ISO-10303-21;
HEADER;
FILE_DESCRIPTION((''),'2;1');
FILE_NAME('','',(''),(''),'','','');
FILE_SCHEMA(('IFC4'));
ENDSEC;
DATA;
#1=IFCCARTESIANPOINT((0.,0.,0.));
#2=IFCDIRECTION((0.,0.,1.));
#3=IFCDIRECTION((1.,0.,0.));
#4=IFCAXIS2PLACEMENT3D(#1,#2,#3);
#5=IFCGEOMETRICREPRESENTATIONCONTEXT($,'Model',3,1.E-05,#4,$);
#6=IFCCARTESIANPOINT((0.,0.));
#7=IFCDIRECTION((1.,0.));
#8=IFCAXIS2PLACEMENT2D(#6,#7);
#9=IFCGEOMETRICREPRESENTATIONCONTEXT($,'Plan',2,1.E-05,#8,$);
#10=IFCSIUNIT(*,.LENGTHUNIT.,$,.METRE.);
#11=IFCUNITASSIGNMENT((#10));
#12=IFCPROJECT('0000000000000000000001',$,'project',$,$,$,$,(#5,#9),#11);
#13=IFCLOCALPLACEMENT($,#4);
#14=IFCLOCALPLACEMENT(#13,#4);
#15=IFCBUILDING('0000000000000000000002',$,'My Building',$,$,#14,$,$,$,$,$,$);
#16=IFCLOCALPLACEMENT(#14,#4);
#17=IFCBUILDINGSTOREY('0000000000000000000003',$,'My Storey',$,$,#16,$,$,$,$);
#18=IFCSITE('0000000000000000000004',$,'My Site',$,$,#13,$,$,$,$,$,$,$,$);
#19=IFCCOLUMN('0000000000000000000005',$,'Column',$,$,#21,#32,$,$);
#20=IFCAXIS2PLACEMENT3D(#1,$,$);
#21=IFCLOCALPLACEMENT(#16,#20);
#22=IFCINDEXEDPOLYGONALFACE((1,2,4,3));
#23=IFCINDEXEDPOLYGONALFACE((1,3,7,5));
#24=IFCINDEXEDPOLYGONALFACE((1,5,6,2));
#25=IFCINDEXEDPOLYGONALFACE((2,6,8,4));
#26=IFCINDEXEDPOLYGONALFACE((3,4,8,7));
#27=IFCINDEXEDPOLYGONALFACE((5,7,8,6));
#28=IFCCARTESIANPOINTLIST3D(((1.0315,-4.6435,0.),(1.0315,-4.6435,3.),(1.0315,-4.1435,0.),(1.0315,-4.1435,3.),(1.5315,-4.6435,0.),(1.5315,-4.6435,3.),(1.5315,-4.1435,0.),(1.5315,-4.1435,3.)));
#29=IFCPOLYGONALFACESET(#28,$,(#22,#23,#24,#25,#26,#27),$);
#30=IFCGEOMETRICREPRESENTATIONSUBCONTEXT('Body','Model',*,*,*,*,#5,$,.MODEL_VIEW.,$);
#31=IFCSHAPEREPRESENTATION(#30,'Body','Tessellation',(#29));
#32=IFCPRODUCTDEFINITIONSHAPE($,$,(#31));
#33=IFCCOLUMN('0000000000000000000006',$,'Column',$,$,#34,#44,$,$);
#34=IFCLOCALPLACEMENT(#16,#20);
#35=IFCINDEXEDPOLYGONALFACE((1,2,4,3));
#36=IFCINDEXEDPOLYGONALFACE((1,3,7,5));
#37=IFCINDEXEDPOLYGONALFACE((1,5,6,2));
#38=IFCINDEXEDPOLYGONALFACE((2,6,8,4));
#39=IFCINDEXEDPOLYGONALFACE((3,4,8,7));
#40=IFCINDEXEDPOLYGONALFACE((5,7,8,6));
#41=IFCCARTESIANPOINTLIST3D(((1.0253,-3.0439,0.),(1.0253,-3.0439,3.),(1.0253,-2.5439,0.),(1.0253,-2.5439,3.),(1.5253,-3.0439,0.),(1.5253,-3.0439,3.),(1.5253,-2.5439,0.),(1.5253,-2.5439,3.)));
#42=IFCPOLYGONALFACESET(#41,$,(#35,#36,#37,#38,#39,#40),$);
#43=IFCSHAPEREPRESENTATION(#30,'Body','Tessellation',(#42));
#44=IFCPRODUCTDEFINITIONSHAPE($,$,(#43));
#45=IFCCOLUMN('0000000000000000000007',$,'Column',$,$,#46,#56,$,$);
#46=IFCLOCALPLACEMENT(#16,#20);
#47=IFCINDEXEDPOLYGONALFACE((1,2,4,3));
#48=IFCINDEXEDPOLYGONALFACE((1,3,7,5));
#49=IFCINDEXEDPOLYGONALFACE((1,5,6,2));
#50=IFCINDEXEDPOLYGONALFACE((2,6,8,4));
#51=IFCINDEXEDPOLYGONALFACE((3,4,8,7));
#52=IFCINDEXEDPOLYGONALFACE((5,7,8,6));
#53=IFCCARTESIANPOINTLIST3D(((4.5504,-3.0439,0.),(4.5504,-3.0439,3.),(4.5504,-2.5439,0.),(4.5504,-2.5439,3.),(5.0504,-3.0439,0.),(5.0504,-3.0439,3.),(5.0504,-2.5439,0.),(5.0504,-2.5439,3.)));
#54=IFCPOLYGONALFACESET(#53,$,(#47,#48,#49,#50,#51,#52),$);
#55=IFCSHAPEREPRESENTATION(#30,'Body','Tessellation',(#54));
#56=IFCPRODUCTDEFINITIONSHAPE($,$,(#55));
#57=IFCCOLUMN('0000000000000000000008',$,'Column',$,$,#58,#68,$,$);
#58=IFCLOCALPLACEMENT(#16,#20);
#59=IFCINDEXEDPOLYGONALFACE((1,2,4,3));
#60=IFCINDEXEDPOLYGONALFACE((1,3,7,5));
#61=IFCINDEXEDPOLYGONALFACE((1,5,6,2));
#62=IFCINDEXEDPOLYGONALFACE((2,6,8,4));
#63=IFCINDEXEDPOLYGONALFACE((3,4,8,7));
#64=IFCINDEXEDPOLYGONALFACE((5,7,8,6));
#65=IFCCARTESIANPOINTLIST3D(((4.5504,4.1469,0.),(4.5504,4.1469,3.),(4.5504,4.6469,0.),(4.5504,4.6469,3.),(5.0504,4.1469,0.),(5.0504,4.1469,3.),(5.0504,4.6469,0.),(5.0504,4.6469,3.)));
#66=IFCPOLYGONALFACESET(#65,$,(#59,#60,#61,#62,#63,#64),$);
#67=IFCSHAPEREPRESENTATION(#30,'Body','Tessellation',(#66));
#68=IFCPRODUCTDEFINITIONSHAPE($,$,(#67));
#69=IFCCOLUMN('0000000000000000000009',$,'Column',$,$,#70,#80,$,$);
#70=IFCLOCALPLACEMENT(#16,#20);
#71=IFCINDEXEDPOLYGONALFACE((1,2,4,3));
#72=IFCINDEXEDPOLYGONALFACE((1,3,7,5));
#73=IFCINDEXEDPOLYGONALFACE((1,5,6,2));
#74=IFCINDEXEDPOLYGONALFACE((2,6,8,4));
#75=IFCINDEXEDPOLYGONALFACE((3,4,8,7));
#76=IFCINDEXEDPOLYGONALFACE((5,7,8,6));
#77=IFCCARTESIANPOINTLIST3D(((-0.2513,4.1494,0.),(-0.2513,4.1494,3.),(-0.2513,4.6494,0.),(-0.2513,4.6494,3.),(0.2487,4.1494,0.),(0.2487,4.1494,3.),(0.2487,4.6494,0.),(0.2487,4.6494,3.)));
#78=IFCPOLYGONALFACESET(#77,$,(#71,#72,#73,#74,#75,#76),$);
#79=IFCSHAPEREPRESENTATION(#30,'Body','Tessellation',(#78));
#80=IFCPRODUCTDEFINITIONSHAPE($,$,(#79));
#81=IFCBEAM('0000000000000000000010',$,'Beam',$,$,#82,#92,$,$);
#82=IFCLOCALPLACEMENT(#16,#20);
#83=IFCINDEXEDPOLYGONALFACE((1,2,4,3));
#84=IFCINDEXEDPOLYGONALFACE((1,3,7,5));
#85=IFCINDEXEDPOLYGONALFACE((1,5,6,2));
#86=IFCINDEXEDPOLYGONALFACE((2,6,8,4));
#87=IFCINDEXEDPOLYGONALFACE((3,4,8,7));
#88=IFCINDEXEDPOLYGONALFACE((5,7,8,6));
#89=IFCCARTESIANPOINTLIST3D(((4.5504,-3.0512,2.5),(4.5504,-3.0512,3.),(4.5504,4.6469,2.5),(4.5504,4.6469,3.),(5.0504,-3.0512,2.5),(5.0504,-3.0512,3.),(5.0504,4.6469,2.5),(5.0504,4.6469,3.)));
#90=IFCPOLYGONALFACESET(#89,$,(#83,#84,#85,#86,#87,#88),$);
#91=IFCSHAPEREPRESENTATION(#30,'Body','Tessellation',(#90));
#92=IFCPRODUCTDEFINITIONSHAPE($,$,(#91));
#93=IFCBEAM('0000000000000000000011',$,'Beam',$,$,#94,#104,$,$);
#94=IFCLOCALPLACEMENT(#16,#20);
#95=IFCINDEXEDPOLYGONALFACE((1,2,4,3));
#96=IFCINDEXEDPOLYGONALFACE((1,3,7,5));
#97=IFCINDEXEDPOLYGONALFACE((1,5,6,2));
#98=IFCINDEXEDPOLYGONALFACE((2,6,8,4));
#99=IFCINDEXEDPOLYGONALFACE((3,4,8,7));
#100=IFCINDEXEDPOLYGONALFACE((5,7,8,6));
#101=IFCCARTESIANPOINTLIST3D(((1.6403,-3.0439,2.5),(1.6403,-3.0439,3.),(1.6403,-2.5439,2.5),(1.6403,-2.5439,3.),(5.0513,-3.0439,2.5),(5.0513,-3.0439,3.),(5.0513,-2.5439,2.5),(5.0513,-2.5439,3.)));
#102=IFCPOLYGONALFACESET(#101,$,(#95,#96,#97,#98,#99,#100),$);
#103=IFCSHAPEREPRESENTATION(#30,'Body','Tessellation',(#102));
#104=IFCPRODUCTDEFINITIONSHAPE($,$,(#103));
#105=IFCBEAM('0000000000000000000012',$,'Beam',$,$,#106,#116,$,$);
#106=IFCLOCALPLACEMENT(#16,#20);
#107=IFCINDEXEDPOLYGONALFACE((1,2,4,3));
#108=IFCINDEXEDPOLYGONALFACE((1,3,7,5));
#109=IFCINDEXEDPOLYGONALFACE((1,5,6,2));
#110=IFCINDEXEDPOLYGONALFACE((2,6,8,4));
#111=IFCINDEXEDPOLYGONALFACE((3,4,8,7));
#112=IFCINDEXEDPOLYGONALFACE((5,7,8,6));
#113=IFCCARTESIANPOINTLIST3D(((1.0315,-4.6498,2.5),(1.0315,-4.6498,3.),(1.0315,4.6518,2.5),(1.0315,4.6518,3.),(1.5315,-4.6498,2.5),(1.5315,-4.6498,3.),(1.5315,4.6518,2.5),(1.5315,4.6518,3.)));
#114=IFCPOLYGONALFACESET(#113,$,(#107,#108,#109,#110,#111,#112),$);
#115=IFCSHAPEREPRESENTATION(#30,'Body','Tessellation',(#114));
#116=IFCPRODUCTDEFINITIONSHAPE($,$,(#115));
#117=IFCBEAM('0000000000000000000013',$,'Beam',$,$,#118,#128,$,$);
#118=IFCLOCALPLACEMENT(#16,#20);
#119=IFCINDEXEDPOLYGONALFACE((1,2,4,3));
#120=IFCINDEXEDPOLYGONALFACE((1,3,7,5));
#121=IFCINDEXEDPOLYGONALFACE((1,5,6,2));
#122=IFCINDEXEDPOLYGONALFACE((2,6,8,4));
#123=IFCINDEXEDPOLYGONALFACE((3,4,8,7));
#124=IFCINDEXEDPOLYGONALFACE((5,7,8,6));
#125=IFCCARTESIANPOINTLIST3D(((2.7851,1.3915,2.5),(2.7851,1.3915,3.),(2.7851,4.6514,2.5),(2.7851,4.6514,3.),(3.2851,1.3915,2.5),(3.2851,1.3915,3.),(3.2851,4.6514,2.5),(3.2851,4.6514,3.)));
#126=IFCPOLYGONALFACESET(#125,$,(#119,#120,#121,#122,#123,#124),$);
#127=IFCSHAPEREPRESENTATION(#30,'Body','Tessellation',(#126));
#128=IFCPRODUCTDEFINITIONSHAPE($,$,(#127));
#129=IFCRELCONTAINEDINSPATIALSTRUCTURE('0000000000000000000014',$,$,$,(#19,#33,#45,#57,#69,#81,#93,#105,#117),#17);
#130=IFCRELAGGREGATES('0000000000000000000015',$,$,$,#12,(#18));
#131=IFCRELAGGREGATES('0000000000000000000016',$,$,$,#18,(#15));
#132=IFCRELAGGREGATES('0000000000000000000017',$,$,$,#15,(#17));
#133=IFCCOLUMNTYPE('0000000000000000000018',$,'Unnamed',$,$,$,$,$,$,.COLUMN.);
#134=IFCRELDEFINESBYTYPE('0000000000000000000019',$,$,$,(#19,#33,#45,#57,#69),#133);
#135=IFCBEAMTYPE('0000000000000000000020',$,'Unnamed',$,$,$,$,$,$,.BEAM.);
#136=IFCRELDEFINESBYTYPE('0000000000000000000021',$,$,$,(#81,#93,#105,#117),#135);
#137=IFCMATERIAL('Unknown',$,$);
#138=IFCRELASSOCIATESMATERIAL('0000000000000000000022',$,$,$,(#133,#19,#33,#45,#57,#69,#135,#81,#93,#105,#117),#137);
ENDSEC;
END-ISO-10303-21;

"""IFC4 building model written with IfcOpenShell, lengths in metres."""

from ifc_helpers import new_model, si_unit, frame, origin_with_axes, origin_2d_with_axis, place, context, subcontext, project, spatial, rectangle, extrude, material, material_profile, profile_set, profile_usage, type_object, element, save


model = new_model("IFC4")

# Units and contexts
model_context = context("Model", 3, precision=1e-05, world=origin_with_axes())
plan_context = context("Plan", 2, precision=1e-05, world=origin_2d_with_axis())
body_context_1 = subcontext(model_context, "Body", "Model", "MODEL_VIEW")
ifc_project = project(units=[si_unit("LENGTHUNIT", "METRE")], contexts=[model_context, plan_context])

# Site, building, storey
site_placement = place(None, origin_with_axes())
site = spatial("IfcSite", under=ifc_project, at=site_placement, Name="My Site")
building_placement = place(site_placement, origin_with_axes())
building = spatial("IfcBuilding", under=site, at=building_placement, Name="My Building")
storey_placement = place(building_placement, origin_with_axes())
storey = spatial("IfcBuildingStorey", under=building, at=storey_placement, Name="My Storey")

# Columns
ifc_material = material(Name="Unknown")
ifc_material_profile_1 = material_profile(ifc_material, rectangle(XDim=0.5, YDim=0.5))
ifc_profile_set_1 = profile_set([ifc_material_profile_1])
ifc_profile_usage_1 = profile_usage(ifc_profile_set_1, cardinal=5)
column_type = type_object("IfcColumnType", Name="Unnamed", PredefinedType="COLUMN", material=ifc_profile_set_1)
column_1_placement = place(storey_placement, frame((1.2815, -4.3935, 0.0), z_axis=(0.0, 0.0, 1.0), x_axis=(1.0, 0.0, 0.0)))
element("IfcColumn", 1, at=column_1_placement, inside=storey, type_object=column_type, material=ifc_profile_usage_1, Name="Column", context=body_context_1, shape_type="SweptSolid", body=[
    extrude(rectangle(XDim=0.5, YDim=0.5), origin_with_axes(), (0.0, 0.0, 1.0), 3.0),
])
ifc_profile_usage_2 = profile_usage(ifc_profile_set_1, cardinal=5)
column_2_placement = place(storey_placement, frame((1.2753, -2.7939, 0.0), z_axis=(0.0, 0.0, 1.0), x_axis=(1.0, 0.0, 0.0)))
element("IfcColumn", 2, at=column_2_placement, inside=storey, type_object=column_type, material=ifc_profile_usage_2, Name="Column", context=body_context_1, shape_type="SweptSolid", body=[
    extrude(rectangle(XDim=0.5, YDim=0.5), origin_with_axes(), (0.0, 0.0, 1.0), 3.0),
])
ifc_profile_usage_3 = profile_usage(ifc_profile_set_1, cardinal=5)
column_3_placement = place(storey_placement, frame((4.8004, -2.7939, 0.0), z_axis=(0.0, 0.0, 1.0), x_axis=(1.0, 0.0, 0.0)))
element("IfcColumn", 3, at=column_3_placement, inside=storey, type_object=column_type, material=ifc_profile_usage_3, Name="Column", context=body_context_1, shape_type="SweptSolid", body=[
    extrude(rectangle(XDim=0.5, YDim=0.5), origin_with_axes(), (0.0, 0.0, 1.0), 3.0),
])
ifc_profile_usage_4 = profile_usage(ifc_profile_set_1, cardinal=5)
column_4_placement = place(storey_placement, frame((4.8004, 4.3969, 0.0), z_axis=(0.0, 0.0, 1.0), x_axis=(1.0, 0.0, 0.0)))
element("IfcColumn", 4, at=column_4_placement, inside=storey, type_object=column_type, material=ifc_profile_usage_4, Name="Column", context=body_context_1, shape_type="SweptSolid", body=[
    extrude(rectangle(XDim=0.5, YDim=0.5), origin_with_axes(), (0.0, 0.0, 1.0), 3.0),
])
ifc_profile_usage_5 = profile_usage(ifc_profile_set_1, cardinal=5)
column_5_placement = place(storey_placement, frame((-0.0013, 4.3994, 0.0), z_axis=(0.0, 0.0, 1.0), x_axis=(1.0, 0.0, 0.0)))
element("IfcColumn", 5, at=column_5_placement, inside=storey, type_object=column_type, material=ifc_profile_usage_5, Name="Column", context=body_context_1, shape_type="SweptSolid", body=[
    extrude(rectangle(XDim=0.5, YDim=0.5), origin_with_axes(), (0.0, 0.0, 1.0), 3.0),
])

# Beams
ifc_material_profile_2 = material_profile(ifc_material, rectangle(XDim=0.5, YDim=0.5))
ifc_profile_set_2 = profile_set([ifc_material_profile_2])
ifc_profile_usage_6 = profile_usage(ifc_profile_set_2, cardinal=5)
beam_type = type_object("IfcBeamType", Name="Unnamed", PredefinedType="BEAM", material=ifc_profile_set_2)
beam_1_placement = place(storey_placement, frame((4.8004, 4.6469, 2.75), z_axis=(0.0, -1.0, 0.0), x_axis=(1.0, 0.0, 0.0)))
element("IfcBeam", 6, at=beam_1_placement, inside=storey, type_object=beam_type, material=ifc_profile_usage_6, Name="Beam", context=body_context_1, shape_type="SweptSolid", body=[
    extrude(rectangle(XDim=0.5, YDim=0.5), origin_with_axes(), (0.0, 0.0, 1.0), 7.6981),
])
ifc_profile_usage_7 = profile_usage(ifc_profile_set_2, cardinal=5)
beam_2_placement = place(storey_placement, frame((5.0513, -2.7939, 2.75), z_axis=(-1.0, 0.0, 0.0), x_axis=(0.0, -1.0, 0.0)))
element("IfcBeam", 7, at=beam_2_placement, inside=storey, type_object=beam_type, material=ifc_profile_usage_7, Name="Beam", context=body_context_1, shape_type="SweptSolid", body=[
    extrude(rectangle(XDim=0.5, YDim=0.5), origin_with_axes(), (0.0, 0.0, 1.0), 3.411),
])
ifc_profile_usage_8 = profile_usage(ifc_profile_set_2, cardinal=5)
beam_3_placement = place(storey_placement, frame((1.2815, 4.6518, 2.75), z_axis=(0.0, -1.0, 0.0), x_axis=(1.0, 0.0, 0.0)))
element("IfcBeam", 8, at=beam_3_placement, inside=storey, type_object=beam_type, material=ifc_profile_usage_8, Name="Beam", context=body_context_1, shape_type="SweptSolid", body=[
    extrude(rectangle(XDim=0.5, YDim=0.5), origin_with_axes(), (0.0, 0.0, 1.0), 9.3016),
])
ifc_profile_usage_9 = profile_usage(ifc_profile_set_2, cardinal=5)
beam_4_placement = place(storey_placement, frame((3.0351, 4.6514, 2.75), z_axis=(0.0, -1.0, 0.0), x_axis=(1.0, 0.0, 0.0)))
element("IfcBeam", 9, at=beam_4_placement, inside=storey, type_object=beam_type, material=ifc_profile_usage_9, Name="Beam", context=body_context_1, shape_type="SweptSolid", body=[
    extrude(rectangle(XDim=0.5, YDim=0.5), origin_with_axes(), (0.0, 0.0, 1.0), 3.2599),
])

save(model, "model.ifc")
